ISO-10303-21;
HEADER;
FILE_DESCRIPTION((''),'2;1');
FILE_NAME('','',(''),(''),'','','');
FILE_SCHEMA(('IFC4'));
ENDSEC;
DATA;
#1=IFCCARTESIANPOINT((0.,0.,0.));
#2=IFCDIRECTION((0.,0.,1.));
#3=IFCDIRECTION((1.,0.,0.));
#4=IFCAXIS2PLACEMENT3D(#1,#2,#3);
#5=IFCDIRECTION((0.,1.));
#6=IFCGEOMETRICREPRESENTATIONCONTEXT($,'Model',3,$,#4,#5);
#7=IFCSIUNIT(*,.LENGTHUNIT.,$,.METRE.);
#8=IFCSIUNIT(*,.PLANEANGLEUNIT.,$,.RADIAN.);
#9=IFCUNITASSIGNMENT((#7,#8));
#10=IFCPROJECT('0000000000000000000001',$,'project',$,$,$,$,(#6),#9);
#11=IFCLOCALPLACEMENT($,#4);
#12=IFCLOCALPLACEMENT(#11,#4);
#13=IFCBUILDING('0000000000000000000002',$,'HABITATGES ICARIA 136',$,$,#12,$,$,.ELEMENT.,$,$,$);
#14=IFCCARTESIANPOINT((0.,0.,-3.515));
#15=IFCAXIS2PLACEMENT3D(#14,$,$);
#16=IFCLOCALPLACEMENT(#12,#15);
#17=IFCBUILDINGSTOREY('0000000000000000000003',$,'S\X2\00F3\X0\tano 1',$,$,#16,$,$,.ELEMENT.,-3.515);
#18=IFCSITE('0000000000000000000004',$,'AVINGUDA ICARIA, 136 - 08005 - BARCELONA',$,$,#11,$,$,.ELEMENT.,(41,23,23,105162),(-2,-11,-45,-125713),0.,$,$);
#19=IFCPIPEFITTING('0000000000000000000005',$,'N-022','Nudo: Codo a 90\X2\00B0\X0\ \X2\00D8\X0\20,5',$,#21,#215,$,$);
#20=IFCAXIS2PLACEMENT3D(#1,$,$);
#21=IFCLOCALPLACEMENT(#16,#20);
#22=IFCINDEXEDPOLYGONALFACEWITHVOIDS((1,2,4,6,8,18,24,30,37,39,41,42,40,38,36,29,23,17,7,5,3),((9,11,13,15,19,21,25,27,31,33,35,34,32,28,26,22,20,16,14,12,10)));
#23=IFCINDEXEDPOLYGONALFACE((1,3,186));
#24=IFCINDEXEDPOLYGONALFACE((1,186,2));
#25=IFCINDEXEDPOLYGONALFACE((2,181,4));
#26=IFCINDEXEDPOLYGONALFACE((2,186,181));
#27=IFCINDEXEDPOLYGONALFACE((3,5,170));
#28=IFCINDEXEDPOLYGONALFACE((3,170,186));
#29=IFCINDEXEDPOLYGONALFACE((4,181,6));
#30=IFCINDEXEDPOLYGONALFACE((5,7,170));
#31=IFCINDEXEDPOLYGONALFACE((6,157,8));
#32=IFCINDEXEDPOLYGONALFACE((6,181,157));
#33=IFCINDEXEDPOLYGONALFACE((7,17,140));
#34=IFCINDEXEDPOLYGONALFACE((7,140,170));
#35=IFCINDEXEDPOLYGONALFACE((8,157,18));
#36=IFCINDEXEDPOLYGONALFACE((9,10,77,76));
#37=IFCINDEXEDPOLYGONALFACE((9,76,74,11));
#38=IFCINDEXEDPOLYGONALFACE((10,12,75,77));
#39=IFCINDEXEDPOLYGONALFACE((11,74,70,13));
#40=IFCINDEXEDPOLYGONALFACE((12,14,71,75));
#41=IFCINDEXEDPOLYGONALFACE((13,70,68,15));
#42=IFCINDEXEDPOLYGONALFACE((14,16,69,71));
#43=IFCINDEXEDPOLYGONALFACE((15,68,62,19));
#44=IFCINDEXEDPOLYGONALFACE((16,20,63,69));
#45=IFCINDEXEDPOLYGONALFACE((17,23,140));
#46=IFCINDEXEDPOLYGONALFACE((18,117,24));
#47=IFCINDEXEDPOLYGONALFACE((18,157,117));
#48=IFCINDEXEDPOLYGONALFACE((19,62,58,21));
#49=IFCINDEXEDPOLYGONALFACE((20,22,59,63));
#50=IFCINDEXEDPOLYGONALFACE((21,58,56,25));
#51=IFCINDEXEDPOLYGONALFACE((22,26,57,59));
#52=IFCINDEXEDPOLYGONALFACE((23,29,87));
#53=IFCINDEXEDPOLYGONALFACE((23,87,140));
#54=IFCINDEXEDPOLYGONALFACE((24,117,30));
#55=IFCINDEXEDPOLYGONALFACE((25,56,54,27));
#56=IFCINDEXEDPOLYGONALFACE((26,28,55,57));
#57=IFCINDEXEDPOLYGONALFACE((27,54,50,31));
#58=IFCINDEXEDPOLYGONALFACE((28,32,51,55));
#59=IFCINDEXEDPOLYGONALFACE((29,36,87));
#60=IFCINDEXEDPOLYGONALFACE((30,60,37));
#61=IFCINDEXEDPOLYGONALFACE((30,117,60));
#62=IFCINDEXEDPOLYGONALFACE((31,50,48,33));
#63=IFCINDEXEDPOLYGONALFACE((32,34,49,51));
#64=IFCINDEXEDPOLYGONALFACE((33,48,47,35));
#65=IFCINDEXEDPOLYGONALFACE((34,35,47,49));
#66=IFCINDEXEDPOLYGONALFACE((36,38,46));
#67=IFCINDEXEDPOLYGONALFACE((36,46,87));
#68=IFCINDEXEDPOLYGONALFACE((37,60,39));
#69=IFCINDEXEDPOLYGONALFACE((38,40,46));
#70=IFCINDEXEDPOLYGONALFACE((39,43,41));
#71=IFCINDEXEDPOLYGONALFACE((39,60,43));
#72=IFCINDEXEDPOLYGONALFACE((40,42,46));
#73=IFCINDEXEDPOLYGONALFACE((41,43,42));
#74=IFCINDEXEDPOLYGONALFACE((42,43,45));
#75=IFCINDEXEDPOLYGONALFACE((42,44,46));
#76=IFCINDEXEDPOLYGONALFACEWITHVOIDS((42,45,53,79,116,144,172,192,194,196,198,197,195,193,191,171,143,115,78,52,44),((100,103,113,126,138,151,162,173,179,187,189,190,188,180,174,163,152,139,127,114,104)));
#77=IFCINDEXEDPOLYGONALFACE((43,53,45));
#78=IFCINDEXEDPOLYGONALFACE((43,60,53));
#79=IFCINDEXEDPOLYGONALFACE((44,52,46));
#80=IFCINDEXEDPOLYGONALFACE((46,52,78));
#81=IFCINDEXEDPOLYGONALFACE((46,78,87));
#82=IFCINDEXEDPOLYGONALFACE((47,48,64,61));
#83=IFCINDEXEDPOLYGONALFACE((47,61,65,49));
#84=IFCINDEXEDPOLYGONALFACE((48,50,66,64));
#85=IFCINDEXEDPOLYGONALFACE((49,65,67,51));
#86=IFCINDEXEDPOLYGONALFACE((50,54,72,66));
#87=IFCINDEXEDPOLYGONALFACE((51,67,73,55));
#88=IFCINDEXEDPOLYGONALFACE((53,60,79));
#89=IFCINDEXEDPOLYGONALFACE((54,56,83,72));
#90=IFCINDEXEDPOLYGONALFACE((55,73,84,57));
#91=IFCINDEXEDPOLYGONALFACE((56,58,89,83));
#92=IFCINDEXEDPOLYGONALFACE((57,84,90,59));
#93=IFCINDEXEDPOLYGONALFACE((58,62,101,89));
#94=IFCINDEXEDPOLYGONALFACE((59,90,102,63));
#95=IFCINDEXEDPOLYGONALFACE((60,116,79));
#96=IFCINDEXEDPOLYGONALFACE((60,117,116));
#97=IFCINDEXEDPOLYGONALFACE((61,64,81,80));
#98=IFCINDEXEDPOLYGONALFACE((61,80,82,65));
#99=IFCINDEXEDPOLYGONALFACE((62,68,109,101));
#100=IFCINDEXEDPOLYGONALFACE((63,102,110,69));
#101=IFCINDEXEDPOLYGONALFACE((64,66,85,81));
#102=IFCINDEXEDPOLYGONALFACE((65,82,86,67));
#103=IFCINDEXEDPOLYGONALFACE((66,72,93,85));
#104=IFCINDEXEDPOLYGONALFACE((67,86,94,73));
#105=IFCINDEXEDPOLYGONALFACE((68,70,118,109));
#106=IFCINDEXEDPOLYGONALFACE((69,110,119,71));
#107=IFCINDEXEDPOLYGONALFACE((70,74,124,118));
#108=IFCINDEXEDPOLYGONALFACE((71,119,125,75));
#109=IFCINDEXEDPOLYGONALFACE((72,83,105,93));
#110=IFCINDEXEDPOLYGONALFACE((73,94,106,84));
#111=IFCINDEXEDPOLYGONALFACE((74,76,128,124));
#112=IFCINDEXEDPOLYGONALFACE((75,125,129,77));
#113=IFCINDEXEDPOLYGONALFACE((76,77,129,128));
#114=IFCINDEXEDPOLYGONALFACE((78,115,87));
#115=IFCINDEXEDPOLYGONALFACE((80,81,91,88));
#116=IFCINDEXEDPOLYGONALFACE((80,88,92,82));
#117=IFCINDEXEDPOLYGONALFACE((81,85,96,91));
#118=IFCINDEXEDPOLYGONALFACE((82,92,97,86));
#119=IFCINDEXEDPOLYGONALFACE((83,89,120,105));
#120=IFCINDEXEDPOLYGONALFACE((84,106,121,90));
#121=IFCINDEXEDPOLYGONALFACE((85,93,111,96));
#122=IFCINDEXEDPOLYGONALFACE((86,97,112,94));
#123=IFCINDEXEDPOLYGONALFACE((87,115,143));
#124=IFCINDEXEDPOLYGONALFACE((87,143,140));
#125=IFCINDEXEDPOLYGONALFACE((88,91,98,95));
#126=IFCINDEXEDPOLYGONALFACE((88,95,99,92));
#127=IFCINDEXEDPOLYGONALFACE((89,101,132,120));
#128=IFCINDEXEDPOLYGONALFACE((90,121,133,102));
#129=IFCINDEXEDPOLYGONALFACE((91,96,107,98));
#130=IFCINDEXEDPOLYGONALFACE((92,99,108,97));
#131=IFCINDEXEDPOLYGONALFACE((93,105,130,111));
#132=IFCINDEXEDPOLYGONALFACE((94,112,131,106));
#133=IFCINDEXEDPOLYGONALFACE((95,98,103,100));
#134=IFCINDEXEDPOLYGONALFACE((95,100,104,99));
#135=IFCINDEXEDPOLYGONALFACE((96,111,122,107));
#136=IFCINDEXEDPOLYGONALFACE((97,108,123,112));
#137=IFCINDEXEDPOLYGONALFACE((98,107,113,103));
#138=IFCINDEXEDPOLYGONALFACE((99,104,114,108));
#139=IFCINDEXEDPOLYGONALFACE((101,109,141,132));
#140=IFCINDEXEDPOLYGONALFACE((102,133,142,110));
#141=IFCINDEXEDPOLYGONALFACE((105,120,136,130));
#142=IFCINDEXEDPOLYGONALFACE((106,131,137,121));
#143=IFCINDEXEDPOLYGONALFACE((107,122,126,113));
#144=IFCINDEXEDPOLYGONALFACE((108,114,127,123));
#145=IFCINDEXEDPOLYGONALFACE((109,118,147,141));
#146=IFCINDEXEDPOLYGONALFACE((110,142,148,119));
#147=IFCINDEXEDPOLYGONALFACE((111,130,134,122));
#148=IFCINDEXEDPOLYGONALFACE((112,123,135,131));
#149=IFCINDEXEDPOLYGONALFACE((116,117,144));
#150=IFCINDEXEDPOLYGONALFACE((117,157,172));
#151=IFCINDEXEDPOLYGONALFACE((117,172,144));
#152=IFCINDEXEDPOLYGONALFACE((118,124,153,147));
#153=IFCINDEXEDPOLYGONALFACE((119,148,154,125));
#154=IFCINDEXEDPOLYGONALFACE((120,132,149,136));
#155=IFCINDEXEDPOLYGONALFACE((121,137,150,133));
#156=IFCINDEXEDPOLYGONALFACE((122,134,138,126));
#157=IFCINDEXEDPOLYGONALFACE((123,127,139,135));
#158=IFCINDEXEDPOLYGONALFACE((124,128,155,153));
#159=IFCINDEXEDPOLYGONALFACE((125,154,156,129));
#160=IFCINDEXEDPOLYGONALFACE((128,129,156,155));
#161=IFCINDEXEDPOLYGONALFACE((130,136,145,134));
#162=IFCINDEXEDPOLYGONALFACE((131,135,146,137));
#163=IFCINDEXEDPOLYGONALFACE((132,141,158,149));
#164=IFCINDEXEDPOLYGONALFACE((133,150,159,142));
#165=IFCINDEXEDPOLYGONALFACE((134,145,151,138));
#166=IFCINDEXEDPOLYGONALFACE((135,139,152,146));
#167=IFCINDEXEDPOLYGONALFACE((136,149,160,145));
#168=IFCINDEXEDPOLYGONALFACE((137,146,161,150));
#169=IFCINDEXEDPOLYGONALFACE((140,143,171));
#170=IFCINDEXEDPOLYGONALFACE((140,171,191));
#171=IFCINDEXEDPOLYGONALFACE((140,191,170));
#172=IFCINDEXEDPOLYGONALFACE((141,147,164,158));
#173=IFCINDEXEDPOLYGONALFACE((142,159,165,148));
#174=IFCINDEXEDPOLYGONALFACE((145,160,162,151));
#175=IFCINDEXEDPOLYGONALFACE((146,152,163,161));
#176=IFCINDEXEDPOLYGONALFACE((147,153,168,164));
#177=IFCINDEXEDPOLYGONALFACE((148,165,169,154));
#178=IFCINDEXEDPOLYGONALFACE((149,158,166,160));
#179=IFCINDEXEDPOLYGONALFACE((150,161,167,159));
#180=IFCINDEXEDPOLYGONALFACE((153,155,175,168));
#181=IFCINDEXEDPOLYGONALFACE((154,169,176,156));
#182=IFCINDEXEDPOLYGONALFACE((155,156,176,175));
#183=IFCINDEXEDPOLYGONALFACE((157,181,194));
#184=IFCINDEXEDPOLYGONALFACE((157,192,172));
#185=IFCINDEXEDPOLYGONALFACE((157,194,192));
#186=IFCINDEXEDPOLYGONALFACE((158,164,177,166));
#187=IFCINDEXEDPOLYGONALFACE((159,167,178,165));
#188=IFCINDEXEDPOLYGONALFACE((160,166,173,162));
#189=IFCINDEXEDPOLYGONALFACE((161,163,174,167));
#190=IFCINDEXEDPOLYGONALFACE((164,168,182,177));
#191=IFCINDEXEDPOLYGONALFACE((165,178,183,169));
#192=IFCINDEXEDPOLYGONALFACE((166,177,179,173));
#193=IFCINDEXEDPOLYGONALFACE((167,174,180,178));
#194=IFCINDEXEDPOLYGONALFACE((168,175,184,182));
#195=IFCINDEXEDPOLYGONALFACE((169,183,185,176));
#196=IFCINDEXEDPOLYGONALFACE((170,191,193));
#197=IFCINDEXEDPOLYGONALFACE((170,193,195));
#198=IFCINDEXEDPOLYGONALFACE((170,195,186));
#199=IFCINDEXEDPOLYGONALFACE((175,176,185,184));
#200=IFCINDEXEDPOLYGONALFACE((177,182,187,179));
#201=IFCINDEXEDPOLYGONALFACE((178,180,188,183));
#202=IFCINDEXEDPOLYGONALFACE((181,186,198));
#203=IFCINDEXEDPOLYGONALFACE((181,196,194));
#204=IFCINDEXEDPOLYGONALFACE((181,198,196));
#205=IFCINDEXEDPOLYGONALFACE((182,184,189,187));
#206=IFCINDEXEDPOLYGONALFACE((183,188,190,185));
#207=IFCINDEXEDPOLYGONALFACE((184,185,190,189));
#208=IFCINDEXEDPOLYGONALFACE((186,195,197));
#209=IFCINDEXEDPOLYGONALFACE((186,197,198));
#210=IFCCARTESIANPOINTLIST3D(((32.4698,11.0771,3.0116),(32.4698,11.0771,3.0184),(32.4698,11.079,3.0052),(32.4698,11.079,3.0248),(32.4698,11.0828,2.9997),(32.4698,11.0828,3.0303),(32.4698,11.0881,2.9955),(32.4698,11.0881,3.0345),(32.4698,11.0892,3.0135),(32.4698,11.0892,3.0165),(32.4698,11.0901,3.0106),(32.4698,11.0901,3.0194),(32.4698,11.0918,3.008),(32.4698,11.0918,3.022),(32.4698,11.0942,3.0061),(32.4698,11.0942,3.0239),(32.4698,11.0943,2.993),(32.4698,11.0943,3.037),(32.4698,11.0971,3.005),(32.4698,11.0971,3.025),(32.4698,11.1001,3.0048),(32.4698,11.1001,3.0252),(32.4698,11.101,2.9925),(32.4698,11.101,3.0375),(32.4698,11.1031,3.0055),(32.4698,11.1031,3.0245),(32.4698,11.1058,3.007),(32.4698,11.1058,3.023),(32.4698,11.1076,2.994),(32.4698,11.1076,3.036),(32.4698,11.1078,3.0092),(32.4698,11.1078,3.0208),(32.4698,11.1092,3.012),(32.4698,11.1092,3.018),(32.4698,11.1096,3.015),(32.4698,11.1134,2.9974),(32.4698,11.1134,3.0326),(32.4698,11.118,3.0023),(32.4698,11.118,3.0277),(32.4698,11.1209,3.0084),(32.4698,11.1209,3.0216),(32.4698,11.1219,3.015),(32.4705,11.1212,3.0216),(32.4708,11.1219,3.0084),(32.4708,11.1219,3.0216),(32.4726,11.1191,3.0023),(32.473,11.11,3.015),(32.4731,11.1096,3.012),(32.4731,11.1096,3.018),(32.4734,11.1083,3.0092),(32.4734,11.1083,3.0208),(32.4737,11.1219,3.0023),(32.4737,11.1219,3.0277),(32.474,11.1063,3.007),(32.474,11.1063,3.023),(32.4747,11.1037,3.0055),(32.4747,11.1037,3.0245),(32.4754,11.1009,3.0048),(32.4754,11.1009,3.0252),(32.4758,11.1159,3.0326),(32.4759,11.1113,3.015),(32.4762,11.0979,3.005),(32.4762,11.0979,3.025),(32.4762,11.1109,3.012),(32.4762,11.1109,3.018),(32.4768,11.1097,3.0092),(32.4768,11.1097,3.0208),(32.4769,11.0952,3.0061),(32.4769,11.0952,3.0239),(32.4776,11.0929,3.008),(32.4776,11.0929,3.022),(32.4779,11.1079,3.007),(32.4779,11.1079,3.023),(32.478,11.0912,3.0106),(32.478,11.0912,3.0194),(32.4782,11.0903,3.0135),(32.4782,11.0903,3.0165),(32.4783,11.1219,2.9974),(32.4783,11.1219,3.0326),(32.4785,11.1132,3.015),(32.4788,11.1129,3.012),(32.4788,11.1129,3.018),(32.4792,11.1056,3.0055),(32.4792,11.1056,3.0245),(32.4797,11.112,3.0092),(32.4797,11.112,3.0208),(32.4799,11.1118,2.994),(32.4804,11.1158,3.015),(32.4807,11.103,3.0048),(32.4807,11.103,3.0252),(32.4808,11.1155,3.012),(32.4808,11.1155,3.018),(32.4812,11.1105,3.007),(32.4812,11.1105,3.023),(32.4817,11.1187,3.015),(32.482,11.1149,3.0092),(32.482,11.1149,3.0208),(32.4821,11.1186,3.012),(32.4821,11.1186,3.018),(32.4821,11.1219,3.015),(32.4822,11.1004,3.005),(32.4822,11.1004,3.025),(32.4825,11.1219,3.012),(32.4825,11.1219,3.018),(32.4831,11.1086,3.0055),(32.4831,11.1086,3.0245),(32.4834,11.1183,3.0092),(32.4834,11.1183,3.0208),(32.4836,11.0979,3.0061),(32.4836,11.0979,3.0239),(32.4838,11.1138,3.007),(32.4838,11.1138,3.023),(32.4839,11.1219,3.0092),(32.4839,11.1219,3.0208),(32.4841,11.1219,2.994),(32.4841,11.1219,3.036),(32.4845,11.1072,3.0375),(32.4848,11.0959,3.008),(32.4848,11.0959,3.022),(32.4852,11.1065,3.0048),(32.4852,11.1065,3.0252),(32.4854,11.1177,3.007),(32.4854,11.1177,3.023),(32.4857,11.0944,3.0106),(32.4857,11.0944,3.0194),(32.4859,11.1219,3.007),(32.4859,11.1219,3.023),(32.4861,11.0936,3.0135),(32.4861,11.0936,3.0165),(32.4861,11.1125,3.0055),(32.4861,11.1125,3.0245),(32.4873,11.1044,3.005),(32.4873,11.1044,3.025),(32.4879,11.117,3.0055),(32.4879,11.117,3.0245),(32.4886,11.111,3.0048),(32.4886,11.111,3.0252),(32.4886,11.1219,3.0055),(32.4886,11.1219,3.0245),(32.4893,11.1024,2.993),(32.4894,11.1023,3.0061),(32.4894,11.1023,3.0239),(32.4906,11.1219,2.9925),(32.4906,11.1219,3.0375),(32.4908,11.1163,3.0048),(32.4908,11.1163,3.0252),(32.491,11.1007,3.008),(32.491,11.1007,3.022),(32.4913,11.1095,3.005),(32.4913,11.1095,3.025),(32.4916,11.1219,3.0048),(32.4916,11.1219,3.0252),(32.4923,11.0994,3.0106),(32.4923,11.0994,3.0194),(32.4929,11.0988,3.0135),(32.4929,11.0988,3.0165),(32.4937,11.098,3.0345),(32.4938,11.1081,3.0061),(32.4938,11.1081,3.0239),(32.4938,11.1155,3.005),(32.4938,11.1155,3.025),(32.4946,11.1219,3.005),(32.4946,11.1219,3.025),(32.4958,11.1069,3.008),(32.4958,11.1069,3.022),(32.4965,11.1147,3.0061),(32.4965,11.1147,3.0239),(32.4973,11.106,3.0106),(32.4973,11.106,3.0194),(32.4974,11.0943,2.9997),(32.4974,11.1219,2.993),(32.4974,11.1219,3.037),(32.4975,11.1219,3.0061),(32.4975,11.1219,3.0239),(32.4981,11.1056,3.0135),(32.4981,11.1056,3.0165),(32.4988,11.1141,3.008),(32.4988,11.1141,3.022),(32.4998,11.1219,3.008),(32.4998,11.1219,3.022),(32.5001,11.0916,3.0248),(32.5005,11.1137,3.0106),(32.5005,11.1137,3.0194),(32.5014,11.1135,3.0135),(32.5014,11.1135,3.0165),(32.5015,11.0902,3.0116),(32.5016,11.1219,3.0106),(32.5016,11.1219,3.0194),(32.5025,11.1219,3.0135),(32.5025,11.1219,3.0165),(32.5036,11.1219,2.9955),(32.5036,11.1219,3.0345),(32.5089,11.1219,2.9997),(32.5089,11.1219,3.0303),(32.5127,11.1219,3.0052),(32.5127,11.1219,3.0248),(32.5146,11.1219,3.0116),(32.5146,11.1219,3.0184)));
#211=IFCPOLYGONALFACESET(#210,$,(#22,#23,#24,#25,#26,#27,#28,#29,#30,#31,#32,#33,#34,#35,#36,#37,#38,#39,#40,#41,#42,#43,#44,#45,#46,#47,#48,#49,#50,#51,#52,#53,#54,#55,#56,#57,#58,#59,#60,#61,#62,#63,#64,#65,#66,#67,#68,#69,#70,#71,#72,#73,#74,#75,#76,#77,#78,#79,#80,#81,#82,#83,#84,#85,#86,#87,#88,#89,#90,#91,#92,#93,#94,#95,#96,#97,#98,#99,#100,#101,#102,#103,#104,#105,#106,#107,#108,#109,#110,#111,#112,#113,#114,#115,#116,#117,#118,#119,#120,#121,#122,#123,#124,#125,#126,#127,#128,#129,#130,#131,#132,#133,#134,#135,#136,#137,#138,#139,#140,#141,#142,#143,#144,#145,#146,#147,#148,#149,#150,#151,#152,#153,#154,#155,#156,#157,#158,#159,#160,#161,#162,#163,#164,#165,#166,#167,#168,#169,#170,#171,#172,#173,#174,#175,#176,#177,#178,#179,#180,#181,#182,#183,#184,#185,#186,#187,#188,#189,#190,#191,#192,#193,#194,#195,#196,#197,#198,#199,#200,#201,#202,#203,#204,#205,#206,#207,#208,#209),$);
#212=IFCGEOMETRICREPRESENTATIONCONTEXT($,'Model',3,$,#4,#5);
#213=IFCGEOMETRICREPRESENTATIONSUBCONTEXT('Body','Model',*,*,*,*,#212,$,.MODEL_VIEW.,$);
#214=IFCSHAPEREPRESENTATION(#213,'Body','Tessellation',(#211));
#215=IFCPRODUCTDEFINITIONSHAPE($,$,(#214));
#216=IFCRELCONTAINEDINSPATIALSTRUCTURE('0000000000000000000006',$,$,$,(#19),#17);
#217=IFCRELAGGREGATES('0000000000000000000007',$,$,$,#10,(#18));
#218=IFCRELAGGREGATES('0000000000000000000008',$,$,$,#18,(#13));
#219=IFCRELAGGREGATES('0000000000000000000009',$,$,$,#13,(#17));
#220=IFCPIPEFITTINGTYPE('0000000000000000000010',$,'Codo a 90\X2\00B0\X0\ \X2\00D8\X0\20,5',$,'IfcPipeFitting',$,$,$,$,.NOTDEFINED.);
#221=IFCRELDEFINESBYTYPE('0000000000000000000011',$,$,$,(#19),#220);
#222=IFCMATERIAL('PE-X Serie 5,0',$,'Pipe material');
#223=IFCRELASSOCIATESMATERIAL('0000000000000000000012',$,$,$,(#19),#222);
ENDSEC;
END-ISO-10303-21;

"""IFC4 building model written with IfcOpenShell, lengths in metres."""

from ifc_helpers import new_model, entity, si_unit, direction, frame, origin_with_axes, place, context, subcontext, project, spatial, source, transform, mapped, material, type_object, element, save


model = new_model("IFC4")

# Units and contexts
model_context_1 = context("Model", 3, world=origin_with_axes(), true_north=direction((0.0, 1.0)))
model_context_2 = context("Model", 3, world=origin_with_axes(), true_north=direction((0.0, 1.0)))
body_context_1 = subcontext(model_context_2, "Body", "Model", "MODEL_VIEW")
ifc_project = project(units=[si_unit("LENGTHUNIT", "METRE"), si_unit("PLANEANGLEUNIT", "RADIAN")], contexts=[model_context_1])

# Site, building, storey
site_placement = place(None, origin_with_axes())
site = spatial("IfcSite", under=ifc_project, at=site_placement, Name="AVINGUDA ICARIA, 136 - 08005 - BARCELONA", CompositionType="ELEMENT", RefLatitude=(41, 23, 23, 105162), RefLongitude=(-2, -11, -45, -125713), RefElevation=0.0)
building_placement = place(site_placement, origin_with_axes())
building = spatial("IfcBuilding", under=site, at=building_placement, Name="HABITATGES ICARIA 136", CompositionType="ELEMENT")
storey_placement = place(building_placement, frame((0.0, 0.0, -3.515)))
storey = spatial("IfcBuildingStorey", under=building, at=storey_placement, Name="Sótano 1", CompositionType="ELEMENT", Elevation=-3.515)

# Shared definitions
ifc_material_1 = material(Name="PE-X Serie 5,0", Category="Pipe material")
placement_1 = place(None, origin_with_axes())
placement_2 = place(placement_1, origin_with_axes())
placement_3 = place(placement_2, frame((0.0, 0.0, -3.515)))

# Pipe fitting
pipe_fitting_type_1 = type_object("IfcPipeFittingType", Name="Codo a 90° Ø20,5", ApplicableOccurrence="IfcPipeFitting", PredefinedType="NOTDEFINED")
shared_shape_1 = source(origin_with_axes(), body_context_1, "Body", "SweptSolid", [
    entity("IfcRevolvedAreaSolid", entity("IfcCircleHollowProfileDef", "AREA", None, entity("IfcAxis2Placement2D", entity("IfcCartesianPoint", [0.0, 0.0]), entity("IfcDirection", [1.0, 0.0])), 0.0226, 0.0123), entity("IfcAxis2Placement3D", entity("IfcCartesianPoint", [0.0226, 0.0, 0.0]), entity("IfcDirection", [-1.0, 0.0, 0.0]), entity("IfcDirection", [0.0, -1.0, 0.0])), entity("IfcAxis1Placement", entity("IfcCartesianPoint", [0.0226, 0.0, 0.0]), entity("IfcDirection", [0.0, 1.0, 0.0])), 1.570796),
])
pipe_fitting_1_placement = place(placement_3, origin_with_axes())
element("IfcPipeFitting", 1, at=pipe_fitting_1_placement, inside=storey, type_object=pipe_fitting_type_1, material=ifc_material_1, Name="N-022", Description="Nudo: Codo a 90° Ø20,5", context=body_context_1, shape_type="MappedRepresentation", body=[
    mapped(shared_shape_1, transform((32.4923, 11.0994, 3.015), x_axis=(0.0, 1.0, 0.0), y_axis=(1.0, 0.0, 0.0), z_axis=(0.0, 0.0, -1.0), scale=1.0)),
])

save(model, "model.ifc")
